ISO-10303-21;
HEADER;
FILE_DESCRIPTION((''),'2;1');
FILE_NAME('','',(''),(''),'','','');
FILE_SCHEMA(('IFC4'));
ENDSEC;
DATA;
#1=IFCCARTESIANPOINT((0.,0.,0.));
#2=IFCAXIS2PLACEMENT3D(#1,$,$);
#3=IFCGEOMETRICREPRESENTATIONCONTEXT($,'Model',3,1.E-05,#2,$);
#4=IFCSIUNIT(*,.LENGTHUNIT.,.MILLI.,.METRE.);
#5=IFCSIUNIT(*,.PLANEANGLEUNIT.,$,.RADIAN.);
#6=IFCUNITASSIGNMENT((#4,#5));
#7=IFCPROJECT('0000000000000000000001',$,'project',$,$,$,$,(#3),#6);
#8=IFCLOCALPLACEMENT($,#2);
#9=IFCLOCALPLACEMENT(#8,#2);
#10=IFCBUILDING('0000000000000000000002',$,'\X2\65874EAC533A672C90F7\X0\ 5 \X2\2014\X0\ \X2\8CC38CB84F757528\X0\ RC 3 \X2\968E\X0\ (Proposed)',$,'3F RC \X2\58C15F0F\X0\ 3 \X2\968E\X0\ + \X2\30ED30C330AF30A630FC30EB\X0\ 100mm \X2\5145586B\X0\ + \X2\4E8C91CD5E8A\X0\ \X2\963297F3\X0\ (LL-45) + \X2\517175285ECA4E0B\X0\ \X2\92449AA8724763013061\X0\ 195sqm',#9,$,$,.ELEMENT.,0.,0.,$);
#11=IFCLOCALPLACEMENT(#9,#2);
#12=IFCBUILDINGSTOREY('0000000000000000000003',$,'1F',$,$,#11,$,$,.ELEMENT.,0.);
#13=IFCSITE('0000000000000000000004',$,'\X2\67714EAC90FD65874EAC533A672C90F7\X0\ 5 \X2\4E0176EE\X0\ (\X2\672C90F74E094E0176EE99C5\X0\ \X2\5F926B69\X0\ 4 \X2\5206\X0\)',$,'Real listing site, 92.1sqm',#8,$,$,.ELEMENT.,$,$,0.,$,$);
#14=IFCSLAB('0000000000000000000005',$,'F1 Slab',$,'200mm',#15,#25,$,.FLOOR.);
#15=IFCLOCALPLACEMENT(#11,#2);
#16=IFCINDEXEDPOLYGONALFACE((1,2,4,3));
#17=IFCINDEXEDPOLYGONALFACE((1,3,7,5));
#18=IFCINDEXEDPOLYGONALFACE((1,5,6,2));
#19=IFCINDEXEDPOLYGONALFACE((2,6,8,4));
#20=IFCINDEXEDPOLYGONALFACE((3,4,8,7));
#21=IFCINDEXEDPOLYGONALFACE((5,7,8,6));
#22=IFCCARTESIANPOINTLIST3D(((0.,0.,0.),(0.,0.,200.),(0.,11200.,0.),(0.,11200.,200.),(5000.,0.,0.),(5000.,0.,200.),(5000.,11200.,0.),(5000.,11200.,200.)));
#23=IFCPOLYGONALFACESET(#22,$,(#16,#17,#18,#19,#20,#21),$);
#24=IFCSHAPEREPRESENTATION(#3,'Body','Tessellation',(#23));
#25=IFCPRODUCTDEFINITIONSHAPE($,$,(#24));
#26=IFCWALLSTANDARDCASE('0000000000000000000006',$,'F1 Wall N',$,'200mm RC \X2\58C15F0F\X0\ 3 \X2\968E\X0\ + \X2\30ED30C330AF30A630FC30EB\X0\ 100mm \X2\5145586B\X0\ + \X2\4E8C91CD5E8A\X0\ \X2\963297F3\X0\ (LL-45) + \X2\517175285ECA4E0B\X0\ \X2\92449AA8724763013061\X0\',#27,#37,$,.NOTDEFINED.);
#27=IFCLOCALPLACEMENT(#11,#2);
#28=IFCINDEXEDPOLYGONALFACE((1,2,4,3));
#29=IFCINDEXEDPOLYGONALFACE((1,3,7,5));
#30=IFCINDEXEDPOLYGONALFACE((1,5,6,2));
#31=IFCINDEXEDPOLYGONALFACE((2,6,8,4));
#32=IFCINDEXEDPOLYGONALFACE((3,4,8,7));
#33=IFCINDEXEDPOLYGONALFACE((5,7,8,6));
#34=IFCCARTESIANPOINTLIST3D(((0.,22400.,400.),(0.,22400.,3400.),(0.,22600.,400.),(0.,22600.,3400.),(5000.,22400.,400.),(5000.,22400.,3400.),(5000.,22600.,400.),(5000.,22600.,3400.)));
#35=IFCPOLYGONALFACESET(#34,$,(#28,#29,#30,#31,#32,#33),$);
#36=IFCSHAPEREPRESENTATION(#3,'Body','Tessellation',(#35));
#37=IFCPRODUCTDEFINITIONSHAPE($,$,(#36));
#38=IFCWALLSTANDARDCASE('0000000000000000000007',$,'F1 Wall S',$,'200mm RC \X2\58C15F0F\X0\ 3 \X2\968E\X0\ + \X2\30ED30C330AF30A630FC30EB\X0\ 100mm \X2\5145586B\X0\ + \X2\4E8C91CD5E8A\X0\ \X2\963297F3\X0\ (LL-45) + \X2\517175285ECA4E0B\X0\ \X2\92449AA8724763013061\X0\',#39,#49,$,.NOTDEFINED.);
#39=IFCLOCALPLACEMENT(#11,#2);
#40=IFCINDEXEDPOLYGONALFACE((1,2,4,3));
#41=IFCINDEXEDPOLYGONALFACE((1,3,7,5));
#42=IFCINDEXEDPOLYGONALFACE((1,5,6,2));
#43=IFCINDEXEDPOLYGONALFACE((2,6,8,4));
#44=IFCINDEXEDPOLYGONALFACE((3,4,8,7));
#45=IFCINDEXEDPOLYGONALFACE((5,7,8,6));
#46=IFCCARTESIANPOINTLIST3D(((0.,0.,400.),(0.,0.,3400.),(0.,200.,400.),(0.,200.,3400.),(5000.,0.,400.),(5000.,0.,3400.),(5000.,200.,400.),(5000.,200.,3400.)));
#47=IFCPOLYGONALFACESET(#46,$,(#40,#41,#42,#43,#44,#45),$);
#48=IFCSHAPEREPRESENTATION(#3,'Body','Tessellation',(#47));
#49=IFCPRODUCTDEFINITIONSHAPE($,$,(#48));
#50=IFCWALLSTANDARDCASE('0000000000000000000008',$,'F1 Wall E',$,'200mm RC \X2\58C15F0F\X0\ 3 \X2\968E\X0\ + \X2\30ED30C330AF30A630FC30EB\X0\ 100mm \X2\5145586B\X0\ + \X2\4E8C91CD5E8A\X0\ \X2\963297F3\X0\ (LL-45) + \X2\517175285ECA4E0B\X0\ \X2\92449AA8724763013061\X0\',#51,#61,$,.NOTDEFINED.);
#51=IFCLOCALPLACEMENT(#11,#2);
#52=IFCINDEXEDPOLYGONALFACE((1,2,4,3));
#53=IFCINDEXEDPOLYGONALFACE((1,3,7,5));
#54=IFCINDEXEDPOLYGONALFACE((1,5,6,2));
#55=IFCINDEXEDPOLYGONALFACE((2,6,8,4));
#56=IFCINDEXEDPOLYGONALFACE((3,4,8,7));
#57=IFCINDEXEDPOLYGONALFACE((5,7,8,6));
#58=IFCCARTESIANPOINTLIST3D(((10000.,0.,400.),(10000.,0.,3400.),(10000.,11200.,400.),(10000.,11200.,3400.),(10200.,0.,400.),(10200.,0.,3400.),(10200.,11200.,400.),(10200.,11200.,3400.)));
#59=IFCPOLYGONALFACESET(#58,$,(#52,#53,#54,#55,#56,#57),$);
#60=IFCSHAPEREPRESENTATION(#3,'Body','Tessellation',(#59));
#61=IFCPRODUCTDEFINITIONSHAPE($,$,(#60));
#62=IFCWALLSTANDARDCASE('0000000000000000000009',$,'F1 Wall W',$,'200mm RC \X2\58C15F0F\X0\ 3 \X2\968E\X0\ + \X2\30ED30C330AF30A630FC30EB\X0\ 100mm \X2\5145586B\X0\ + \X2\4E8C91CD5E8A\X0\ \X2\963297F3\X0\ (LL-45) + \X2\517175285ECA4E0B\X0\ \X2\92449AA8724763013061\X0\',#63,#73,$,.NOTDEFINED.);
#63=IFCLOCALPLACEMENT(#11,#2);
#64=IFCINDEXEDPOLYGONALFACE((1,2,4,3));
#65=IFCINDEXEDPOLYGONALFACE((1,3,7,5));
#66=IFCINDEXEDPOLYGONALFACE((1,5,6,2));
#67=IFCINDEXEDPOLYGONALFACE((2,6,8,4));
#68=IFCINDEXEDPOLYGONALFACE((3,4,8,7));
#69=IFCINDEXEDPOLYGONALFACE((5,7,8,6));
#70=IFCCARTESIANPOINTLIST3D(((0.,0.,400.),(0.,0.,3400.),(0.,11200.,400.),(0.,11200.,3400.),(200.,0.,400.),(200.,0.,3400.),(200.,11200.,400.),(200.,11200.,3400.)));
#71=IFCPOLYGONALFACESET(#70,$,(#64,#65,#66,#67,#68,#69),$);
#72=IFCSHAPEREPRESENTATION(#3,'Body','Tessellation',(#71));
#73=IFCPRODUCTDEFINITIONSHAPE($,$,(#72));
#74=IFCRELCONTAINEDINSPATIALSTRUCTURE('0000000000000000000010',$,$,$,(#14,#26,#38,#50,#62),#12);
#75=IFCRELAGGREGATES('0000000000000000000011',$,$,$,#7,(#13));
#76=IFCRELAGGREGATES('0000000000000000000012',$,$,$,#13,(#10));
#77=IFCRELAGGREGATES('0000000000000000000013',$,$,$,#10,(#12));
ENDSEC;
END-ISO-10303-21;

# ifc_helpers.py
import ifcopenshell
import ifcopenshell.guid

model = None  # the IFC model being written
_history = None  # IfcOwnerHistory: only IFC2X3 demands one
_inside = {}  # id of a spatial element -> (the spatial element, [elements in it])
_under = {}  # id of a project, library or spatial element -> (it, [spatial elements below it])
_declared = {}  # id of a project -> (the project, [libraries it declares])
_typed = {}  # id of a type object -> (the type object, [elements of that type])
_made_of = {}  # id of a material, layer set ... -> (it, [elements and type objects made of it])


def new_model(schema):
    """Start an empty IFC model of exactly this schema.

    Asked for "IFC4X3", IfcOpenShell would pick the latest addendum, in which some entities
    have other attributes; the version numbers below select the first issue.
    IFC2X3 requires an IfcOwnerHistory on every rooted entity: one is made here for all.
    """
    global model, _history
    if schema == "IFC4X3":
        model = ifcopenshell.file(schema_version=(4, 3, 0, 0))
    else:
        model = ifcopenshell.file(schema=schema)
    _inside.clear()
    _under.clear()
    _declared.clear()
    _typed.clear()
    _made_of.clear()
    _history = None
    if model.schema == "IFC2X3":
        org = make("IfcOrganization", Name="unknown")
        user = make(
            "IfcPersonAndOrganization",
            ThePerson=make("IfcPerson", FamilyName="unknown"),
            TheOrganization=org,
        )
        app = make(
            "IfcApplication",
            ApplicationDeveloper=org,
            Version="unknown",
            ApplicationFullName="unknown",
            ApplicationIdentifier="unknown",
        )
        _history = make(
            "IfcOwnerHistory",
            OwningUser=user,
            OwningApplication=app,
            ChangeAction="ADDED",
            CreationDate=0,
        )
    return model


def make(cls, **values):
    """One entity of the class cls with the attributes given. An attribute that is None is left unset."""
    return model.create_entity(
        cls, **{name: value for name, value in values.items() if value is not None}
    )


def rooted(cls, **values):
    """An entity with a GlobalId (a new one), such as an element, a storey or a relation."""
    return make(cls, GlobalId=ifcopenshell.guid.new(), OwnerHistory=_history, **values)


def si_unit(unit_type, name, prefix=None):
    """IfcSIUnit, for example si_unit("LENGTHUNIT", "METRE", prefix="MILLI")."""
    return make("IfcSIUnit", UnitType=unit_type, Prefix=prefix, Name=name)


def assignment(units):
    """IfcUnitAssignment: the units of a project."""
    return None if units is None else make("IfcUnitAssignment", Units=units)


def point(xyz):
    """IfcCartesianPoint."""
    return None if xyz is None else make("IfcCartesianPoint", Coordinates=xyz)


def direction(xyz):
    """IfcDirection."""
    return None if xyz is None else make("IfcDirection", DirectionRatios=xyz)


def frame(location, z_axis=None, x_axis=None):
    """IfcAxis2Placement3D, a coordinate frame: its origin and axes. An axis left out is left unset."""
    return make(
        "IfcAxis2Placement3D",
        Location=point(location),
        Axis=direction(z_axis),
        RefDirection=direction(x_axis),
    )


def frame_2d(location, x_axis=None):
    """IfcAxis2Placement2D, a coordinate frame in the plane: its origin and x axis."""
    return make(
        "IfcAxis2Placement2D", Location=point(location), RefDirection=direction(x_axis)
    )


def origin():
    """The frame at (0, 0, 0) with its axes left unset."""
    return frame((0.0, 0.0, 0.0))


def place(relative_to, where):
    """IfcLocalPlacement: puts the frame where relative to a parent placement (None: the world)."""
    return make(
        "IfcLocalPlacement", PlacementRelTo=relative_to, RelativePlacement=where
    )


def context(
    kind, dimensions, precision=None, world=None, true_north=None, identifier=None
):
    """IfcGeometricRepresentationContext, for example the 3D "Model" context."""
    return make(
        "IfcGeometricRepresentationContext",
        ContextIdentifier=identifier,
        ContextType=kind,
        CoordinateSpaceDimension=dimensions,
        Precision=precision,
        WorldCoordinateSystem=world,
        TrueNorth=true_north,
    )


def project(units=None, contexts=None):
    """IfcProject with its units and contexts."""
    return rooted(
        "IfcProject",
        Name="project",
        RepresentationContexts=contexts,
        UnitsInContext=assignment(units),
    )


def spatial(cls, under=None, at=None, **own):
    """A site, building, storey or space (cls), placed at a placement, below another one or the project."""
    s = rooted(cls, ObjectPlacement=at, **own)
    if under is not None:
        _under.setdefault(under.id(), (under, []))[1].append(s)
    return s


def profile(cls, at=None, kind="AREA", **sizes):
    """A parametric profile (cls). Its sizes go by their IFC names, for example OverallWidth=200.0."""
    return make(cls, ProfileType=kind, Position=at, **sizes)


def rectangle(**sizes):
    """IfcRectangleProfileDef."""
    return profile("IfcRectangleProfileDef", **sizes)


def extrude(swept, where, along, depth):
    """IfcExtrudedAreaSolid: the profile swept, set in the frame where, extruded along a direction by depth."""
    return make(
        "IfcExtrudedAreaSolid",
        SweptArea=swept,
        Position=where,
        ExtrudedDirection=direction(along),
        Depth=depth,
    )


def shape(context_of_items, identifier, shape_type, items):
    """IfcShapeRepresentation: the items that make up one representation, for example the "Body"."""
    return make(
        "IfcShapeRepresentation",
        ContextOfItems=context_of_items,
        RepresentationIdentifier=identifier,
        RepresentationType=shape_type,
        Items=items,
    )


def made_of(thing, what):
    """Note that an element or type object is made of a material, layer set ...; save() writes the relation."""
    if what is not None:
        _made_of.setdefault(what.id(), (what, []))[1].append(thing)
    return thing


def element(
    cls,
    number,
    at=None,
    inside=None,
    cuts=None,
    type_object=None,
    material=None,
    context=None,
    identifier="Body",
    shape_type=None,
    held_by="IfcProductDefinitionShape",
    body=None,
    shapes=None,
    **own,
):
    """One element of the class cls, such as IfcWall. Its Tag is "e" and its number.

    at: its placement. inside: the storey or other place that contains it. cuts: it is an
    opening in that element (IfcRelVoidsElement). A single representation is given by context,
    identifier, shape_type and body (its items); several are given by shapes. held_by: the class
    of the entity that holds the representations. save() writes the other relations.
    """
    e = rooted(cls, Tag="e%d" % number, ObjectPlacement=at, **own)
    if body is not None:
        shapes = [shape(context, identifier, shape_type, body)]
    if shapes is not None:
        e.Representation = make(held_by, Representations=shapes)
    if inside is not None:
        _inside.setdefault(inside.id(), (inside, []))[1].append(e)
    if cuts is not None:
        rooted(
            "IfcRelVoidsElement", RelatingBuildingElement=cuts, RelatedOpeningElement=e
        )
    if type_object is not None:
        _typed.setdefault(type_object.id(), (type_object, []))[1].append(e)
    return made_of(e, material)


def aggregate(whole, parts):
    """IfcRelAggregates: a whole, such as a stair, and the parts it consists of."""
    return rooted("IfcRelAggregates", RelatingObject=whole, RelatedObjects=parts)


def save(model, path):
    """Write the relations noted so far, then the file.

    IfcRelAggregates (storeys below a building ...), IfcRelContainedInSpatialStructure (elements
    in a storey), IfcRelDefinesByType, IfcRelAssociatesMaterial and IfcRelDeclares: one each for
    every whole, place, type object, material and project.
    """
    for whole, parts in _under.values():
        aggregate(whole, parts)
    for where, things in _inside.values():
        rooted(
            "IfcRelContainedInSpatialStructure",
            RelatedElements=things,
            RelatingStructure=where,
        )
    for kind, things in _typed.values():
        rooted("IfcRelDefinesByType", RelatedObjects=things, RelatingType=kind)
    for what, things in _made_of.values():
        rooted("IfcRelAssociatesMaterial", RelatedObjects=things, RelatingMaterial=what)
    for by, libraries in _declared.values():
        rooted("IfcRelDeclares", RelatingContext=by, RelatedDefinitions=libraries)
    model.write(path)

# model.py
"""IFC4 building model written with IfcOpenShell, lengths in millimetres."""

from ifc_helpers import new_model, si_unit, frame, frame_2d, origin, place, context, project, spatial, rectangle, extrude, element, save


model = new_model("IFC4")

# Units and contexts
model_context = context("Model", 3, precision=1e-05, world=origin())
ifc_project = project(units=[si_unit("LENGTHUNIT", "METRE", prefix="MILLI"), si_unit("PLANEANGLEUNIT", "RADIAN")], contexts=[model_context])

# Site, building, storey
site_placement = place(None, origin())
site = spatial("IfcSite", under=ifc_project, at=site_placement, Name="東京都文京区本郷 5 丁目 (本郷三丁目駅 徒歩 4 分)", ObjectType="Real listing site, 92.1sqm", CompositionType="ELEMENT", RefElevation=0.0)
building_placement = place(site_placement, origin())
building = spatial("IfcBuilding", under=site, at=building_placement, Name="文京区本郷 5 — 賃貸併用 RC 3 階 (Proposed)", ObjectType="3F RC 壁式 3 階 + ロックウール 100mm 充填 + 二重床 防音 (LL-45) + 共用廊下 鉄骨片持ち 195sqm", CompositionType="ELEMENT", ElevationOfRefHeight=0.0, ElevationOfTerrain=0.0)
storey_placement = place(building_placement, origin())
storey = spatial("IfcBuildingStorey", under=building, at=storey_placement, Name="1F", CompositionType="ELEMENT", Elevation=0.0)

# Slab
slab_placement = place(storey_placement, origin())
element("IfcSlab", 1, at=slab_placement, inside=storey, Name="F1 Slab", ObjectType="200mm", PredefinedType="FLOOR", context=model_context, shape_type="SweptSolid", body=[
    extrude(rectangle(XDim=5000.0, YDim=11200.0, at=frame_2d((2500.0, 5600.0))), origin(), (0.0, 0.0, 1.0), 200.0),
])

# Walls
wall_1_placement = place(storey_placement, frame((0.0, 11200.0, 200.0)))
element("IfcWallStandardCase", 2, at=wall_1_placement, inside=storey, Name="F1 Wall N", ObjectType="200mm RC 壁式 3 階 + ロックウール 100mm 充填 + 二重床 防音 (LL-45) + 共用廊下 鉄骨片持ち", PredefinedType="NOTDEFINED", context=model_context, shape_type="SweptSolid", body=[
    extrude(rectangle(XDim=5000.0, YDim=200.0, at=frame_2d((2500.0, 100.0))), frame((0.0, 11200.0, 200.0)), (0.0, 0.0, 1.0), 3000.0),
])
wall_2_placement = place(storey_placement, frame((0.0, 0.0, 200.0)))
element("IfcWallStandardCase", 3, at=wall_2_placement, inside=storey, Name="F1 Wall S", ObjectType="200mm RC 壁式 3 階 + ロックウール 100mm 充填 + 二重床 防音 (LL-45) + 共用廊下 鉄骨片持ち", PredefinedType="NOTDEFINED", context=model_context, shape_type="SweptSolid", body=[
    extrude(rectangle(XDim=5000.0, YDim=200.0, at=frame_2d((2500.0, 100.0))), frame((0.0, 0.0, 200.0)), (0.0, 0.0, 1.0), 3000.0),
])
wall_3_placement = place(storey_placement, frame((5000.0, 0.0, 200.0)))
element("IfcWallStandardCase", 4, at=wall_3_placement, inside=storey, Name="F1 Wall E", ObjectType="200mm RC 壁式 3 階 + ロックウール 100mm 充填 + 二重床 防音 (LL-45) + 共用廊下 鉄骨片持ち", PredefinedType="NOTDEFINED", context=model_context, shape_type="SweptSolid", body=[
    extrude(rectangle(XDim=200.0, YDim=11200.0, at=frame_2d((100.0, 5600.0))), frame((5000.0, 0.0, 200.0)), (0.0, 0.0, 1.0), 3000.0),
])
wall_4_placement = place(storey_placement, frame((0.0, 0.0, 200.0)))
element("IfcWallStandardCase", 5, at=wall_4_placement, inside=storey, Name="F1 Wall W", ObjectType="200mm RC 壁式 3 階 + ロックウール 100mm 充填 + 二重床 防音 (LL-45) + 共用廊下 鉄骨片持ち", PredefinedType="NOTDEFINED", context=model_context, shape_type="SweptSolid", body=[
    extrude(rectangle(XDim=200.0, YDim=11200.0, at=frame_2d((100.0, 5600.0))), frame((0.0, 0.0, 200.0)), (0.0, 0.0, 1.0), 3000.0),
])

save(model, "model.ifc")
